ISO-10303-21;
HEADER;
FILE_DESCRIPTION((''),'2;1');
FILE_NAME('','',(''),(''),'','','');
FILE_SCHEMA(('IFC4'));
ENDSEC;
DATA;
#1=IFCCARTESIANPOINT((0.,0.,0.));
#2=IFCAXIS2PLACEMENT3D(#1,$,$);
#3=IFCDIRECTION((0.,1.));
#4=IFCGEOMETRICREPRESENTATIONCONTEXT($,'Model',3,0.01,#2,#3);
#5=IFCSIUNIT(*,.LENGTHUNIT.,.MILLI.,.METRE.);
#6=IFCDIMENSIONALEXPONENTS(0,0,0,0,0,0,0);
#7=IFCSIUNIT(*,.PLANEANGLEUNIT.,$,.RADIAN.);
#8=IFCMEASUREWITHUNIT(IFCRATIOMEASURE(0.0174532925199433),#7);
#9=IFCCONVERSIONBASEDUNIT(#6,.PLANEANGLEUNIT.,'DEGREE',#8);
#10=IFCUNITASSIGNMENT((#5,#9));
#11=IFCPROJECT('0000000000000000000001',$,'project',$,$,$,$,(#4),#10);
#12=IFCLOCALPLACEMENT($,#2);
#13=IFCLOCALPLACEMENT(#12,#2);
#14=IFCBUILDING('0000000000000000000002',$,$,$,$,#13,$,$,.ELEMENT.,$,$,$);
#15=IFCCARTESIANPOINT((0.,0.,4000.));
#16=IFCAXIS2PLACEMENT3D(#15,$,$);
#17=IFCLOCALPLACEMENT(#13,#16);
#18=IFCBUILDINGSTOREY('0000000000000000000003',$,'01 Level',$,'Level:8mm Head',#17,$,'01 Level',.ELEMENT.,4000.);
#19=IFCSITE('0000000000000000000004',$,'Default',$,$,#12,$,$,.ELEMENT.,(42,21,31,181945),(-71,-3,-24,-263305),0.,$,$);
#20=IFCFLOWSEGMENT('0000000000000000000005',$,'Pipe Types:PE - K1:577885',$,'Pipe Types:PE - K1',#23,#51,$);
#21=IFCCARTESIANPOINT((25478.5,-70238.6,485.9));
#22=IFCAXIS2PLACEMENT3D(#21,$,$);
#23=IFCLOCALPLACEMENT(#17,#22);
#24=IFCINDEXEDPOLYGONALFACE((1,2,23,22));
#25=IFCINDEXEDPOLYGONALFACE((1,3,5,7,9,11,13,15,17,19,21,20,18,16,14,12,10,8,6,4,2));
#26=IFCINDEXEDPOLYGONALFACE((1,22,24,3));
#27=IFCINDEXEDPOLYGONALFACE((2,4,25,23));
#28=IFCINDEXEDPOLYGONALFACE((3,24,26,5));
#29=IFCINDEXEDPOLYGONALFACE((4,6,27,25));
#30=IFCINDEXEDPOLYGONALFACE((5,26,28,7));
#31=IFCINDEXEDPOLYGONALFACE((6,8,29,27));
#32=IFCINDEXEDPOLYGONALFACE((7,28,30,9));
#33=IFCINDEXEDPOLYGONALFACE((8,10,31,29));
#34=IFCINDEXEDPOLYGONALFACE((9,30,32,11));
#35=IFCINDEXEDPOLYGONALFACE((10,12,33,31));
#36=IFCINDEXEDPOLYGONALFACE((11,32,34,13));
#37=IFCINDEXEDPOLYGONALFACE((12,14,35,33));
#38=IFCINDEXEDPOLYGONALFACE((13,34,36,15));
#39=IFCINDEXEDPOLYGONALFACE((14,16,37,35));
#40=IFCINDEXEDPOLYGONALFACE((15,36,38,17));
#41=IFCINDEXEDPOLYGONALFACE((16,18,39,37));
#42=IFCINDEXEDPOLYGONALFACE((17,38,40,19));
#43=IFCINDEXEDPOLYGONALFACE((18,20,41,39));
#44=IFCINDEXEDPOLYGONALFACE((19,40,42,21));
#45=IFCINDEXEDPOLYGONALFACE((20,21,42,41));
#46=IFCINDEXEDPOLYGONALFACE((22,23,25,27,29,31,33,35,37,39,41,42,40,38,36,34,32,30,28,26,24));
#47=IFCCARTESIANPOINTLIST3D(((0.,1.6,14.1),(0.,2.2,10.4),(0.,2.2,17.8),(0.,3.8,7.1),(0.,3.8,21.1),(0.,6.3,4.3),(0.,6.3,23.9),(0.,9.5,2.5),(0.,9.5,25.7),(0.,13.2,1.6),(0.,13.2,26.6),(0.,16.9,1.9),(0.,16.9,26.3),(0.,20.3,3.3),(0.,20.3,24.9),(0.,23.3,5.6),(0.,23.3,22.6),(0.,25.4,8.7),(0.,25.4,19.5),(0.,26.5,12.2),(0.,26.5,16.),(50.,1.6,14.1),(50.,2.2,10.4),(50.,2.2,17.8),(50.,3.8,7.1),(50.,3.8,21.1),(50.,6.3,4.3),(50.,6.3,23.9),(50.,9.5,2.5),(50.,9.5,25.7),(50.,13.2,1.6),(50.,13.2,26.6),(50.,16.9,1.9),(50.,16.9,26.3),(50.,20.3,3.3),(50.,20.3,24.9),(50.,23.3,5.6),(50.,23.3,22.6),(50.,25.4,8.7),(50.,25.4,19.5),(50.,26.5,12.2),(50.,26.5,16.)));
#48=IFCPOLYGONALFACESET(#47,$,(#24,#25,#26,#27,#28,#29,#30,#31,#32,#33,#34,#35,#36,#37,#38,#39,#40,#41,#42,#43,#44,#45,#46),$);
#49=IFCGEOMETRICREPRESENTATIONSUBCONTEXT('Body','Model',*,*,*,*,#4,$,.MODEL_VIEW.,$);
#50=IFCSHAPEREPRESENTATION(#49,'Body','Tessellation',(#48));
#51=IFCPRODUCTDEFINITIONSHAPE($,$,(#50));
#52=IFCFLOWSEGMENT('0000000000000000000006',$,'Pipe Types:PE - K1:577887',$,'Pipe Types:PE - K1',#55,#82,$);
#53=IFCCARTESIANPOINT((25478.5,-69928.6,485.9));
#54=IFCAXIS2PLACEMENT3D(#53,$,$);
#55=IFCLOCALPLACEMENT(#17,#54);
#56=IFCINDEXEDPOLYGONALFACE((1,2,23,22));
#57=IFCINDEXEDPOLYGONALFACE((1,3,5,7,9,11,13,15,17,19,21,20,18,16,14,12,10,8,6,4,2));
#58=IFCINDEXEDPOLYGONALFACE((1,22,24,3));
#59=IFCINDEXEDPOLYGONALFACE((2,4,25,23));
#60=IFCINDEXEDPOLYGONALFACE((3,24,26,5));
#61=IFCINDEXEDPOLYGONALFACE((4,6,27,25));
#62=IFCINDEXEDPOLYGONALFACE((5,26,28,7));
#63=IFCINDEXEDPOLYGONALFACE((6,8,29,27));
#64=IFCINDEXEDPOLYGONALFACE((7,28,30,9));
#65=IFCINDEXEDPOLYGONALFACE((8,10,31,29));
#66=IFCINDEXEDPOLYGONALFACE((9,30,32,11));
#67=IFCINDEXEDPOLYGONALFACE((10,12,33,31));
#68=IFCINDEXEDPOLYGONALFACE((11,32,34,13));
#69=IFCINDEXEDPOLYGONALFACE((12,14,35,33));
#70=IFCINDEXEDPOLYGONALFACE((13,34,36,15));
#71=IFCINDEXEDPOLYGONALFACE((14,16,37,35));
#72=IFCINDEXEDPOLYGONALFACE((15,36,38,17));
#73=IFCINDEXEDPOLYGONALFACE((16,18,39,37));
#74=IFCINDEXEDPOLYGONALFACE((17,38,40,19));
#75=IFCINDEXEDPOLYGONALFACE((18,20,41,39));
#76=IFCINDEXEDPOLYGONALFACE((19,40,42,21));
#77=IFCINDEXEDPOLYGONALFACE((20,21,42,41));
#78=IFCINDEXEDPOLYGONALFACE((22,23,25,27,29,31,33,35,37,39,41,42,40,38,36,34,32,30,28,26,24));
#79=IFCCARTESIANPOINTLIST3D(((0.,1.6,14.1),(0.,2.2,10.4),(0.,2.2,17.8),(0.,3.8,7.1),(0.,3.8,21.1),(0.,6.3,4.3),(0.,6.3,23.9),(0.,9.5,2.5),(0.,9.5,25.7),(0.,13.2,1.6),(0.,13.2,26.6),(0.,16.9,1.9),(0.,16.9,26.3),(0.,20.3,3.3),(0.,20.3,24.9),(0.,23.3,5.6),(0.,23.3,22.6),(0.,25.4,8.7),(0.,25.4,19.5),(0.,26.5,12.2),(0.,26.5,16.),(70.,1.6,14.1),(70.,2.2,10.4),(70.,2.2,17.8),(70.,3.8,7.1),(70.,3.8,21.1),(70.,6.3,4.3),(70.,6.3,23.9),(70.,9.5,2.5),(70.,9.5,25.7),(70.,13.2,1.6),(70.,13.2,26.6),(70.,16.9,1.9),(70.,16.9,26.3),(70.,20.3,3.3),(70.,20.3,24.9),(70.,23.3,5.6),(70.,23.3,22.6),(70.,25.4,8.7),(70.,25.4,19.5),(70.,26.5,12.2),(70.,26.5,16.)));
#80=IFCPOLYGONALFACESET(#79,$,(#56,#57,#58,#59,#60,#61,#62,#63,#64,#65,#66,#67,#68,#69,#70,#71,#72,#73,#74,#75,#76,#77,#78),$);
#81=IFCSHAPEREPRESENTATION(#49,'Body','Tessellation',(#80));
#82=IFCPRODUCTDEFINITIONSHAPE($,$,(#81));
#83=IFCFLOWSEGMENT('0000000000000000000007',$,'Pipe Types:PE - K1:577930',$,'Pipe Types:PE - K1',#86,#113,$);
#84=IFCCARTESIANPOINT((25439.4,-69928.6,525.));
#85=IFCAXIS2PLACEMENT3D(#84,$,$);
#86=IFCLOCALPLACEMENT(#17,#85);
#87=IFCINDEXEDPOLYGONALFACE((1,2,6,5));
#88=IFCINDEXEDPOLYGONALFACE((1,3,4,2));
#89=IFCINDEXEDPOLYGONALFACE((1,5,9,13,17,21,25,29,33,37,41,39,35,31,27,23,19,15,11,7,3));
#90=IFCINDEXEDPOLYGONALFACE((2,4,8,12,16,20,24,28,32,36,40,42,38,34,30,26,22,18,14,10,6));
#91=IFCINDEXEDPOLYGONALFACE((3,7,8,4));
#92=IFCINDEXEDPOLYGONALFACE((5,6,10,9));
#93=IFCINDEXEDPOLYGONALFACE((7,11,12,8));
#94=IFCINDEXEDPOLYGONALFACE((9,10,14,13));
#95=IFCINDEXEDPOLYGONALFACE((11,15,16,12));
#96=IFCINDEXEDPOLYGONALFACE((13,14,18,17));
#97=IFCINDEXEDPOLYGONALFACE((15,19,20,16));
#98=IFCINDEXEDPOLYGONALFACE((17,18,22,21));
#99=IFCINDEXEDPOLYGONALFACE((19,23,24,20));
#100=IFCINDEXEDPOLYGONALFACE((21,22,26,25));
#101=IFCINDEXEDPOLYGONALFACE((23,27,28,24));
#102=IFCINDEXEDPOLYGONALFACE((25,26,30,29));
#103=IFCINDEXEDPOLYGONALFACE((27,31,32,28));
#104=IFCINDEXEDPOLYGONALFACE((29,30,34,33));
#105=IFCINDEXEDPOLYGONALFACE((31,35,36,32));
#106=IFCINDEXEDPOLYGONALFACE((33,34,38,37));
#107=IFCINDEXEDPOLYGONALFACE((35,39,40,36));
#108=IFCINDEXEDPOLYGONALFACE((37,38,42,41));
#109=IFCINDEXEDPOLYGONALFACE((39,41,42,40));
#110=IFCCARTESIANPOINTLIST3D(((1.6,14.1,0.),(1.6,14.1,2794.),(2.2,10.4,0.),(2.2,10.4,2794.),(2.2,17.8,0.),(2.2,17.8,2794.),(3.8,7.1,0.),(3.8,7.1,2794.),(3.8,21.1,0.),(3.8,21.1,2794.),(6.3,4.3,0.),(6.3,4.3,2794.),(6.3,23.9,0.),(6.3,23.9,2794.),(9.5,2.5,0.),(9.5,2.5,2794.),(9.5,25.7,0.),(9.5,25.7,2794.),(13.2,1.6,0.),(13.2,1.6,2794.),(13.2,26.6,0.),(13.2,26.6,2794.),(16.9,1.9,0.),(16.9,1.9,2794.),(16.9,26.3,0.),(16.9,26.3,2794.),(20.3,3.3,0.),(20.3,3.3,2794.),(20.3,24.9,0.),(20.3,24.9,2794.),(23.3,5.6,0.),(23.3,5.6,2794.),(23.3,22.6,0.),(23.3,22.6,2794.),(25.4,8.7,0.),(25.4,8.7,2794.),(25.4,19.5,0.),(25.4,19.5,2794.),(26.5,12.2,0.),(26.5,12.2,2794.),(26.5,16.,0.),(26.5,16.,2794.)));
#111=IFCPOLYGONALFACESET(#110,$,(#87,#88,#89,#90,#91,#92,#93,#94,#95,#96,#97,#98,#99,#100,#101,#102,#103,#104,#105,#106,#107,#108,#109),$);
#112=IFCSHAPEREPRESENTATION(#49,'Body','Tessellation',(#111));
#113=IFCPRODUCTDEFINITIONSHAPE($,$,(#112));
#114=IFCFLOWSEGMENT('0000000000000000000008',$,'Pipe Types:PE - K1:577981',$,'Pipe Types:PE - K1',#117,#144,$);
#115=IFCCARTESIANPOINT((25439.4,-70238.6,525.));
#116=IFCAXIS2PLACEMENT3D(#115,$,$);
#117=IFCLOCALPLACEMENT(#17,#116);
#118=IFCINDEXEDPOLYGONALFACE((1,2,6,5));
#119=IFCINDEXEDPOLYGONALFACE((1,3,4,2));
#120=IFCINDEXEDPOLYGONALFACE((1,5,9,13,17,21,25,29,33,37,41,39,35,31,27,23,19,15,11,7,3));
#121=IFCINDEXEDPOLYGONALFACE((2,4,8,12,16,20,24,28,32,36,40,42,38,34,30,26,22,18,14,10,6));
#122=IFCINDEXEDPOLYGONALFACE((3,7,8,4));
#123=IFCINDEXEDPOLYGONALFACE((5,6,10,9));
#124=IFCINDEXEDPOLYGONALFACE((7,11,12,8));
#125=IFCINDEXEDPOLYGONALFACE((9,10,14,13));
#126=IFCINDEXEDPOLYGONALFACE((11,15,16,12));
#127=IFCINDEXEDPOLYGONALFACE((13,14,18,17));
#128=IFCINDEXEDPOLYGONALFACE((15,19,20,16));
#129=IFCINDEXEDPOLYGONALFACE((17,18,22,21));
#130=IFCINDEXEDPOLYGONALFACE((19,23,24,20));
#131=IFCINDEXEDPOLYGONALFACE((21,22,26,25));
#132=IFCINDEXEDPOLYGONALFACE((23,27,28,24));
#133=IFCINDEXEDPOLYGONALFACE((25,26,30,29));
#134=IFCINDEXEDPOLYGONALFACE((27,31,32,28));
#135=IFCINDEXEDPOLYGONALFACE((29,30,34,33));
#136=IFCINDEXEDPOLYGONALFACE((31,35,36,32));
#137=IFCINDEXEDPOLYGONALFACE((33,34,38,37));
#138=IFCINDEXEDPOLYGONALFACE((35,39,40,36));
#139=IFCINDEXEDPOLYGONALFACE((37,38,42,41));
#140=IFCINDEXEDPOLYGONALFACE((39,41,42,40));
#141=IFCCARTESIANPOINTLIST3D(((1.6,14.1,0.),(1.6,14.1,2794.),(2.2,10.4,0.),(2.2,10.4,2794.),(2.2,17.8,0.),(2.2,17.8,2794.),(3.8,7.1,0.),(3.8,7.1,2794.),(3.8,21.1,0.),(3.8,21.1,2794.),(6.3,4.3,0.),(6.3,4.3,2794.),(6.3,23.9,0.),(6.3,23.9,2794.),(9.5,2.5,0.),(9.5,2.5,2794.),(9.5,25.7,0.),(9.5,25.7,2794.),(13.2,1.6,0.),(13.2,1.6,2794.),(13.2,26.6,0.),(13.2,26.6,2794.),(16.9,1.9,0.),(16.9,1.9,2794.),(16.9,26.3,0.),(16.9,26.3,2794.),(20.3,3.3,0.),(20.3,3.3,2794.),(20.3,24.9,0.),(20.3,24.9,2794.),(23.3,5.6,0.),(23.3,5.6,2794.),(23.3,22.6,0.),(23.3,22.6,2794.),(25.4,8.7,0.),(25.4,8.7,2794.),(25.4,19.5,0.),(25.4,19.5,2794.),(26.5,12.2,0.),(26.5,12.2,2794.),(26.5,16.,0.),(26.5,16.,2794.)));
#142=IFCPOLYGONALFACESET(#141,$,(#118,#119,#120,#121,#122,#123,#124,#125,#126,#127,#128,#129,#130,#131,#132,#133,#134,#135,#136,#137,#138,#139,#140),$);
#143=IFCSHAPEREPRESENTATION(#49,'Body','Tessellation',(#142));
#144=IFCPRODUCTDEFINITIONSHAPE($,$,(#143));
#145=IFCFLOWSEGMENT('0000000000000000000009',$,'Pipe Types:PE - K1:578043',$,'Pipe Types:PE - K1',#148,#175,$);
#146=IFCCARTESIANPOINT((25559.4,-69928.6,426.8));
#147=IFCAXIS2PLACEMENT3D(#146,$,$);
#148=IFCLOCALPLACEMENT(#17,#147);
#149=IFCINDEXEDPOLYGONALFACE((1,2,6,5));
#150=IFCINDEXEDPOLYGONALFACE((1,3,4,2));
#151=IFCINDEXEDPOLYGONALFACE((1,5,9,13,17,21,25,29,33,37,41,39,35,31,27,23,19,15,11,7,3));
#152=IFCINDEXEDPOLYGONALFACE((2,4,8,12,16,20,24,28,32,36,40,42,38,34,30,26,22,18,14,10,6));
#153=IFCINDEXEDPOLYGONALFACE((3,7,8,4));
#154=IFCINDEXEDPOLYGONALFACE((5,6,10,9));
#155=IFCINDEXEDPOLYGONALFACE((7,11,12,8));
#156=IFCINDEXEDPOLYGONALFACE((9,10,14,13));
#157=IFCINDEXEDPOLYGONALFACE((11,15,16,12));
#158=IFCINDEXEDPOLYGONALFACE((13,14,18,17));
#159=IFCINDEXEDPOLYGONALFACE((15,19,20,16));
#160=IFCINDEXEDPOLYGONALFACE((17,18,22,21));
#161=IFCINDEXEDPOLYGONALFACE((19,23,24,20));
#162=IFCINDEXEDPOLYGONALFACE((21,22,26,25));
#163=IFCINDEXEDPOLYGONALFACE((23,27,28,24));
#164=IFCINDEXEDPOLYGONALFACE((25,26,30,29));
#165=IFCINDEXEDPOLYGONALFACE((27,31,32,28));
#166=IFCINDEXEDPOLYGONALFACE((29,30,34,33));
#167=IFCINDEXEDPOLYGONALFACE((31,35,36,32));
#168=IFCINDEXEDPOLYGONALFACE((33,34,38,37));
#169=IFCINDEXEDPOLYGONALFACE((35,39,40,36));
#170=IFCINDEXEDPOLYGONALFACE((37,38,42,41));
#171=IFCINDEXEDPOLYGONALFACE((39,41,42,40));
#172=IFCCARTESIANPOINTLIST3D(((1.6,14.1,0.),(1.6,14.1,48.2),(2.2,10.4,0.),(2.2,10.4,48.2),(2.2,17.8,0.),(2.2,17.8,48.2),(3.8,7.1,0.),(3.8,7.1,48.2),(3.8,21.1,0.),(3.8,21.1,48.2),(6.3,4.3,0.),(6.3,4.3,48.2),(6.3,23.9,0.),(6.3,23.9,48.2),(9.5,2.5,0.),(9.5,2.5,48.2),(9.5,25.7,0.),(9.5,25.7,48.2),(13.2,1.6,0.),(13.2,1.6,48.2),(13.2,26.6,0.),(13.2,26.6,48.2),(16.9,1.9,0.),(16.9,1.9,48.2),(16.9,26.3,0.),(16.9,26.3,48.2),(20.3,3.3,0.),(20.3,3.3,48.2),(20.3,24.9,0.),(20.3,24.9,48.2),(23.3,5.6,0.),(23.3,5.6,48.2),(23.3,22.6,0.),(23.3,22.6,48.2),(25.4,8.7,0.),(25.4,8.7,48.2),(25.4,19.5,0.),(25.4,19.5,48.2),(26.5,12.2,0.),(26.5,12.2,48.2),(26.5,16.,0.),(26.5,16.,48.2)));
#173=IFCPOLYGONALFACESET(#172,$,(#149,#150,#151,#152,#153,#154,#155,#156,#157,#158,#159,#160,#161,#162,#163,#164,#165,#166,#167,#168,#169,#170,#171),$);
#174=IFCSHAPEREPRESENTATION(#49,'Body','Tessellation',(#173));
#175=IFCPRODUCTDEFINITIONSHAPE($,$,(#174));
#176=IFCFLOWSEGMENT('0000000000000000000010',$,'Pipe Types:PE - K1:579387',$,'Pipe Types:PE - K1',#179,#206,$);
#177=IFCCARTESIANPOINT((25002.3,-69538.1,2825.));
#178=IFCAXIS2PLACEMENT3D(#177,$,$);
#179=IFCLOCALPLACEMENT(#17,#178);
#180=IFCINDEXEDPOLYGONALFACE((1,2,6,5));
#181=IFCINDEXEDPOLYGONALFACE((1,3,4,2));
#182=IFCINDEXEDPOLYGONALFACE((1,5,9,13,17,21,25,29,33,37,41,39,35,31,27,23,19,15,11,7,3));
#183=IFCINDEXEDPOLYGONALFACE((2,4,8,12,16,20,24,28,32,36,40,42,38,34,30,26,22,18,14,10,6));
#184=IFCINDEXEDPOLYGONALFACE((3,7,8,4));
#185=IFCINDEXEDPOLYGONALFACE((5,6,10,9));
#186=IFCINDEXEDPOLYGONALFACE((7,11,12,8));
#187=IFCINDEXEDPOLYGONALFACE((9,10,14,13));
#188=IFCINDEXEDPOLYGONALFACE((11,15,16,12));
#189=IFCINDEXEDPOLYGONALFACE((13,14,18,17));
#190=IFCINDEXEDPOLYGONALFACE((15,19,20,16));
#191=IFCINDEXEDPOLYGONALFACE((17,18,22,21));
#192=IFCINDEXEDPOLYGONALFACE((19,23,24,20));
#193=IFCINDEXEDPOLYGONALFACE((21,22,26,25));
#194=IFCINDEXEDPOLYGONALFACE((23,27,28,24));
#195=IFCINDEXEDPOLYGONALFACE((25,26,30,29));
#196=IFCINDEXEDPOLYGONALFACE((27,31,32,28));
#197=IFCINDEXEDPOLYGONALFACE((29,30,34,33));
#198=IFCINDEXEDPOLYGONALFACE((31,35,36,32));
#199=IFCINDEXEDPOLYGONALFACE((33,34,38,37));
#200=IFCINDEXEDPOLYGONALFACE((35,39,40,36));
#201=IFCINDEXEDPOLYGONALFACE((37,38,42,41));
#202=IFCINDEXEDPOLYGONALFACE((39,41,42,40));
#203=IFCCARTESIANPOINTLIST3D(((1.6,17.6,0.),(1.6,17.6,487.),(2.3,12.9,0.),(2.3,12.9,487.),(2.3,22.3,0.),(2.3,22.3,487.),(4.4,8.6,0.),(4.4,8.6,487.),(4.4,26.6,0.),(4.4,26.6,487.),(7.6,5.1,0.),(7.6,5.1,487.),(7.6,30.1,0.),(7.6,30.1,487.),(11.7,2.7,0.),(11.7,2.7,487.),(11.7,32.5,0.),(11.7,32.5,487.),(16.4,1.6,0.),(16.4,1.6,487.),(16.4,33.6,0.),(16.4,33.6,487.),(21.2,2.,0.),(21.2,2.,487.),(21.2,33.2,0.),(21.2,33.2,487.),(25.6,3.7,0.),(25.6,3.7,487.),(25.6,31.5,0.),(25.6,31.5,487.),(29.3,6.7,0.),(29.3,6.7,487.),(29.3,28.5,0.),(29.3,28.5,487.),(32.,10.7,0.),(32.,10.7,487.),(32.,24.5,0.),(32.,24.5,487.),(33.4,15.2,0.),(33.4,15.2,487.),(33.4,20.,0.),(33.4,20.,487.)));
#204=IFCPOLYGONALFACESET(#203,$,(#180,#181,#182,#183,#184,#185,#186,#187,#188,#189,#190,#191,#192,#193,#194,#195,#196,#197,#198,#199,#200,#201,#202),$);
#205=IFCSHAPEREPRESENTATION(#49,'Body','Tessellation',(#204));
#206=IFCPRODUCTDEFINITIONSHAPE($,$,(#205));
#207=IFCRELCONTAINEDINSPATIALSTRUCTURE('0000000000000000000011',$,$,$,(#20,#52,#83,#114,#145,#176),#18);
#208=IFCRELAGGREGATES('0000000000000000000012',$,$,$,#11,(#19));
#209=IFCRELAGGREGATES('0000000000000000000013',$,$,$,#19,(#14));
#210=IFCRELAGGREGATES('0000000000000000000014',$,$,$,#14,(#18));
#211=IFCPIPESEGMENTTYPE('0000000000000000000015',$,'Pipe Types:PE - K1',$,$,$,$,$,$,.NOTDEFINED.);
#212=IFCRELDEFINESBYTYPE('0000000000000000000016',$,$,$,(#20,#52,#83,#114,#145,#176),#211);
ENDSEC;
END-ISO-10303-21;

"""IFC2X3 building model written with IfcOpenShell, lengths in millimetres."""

from ifc_helpers import new_model, entity, si_unit, converted_unit, direction, frame, frame_2d, origin, origin_2d_with_axis, place, context, subcontext, project, spatial, circle, extrude, type_object, element, save


model = new_model("IFC2X3")

# Units and contexts
model_context = context("Model", 3, precision=0.01, world=origin(), true_north=direction((0.0, 1.0)))
body_context = subcontext(model_context, "Body", "Model", "MODEL_VIEW")
ifc_project = project(units=[si_unit("LENGTHUNIT", "METRE", prefix="MILLI"), converted_unit("PLANEANGLEUNIT", "DEGREE", entity("IfcRatioMeasure", 0.0174532925199433), si_unit("PLANEANGLEUNIT", "RADIAN"), dimensions=[0, 0, 0, 0, 0, 0, 0])], contexts=[model_context])

# Site, building, storey
site_placement = place(None, origin())
site = spatial("IfcSite", under=ifc_project, at=site_placement, Name="Default", CompositionType="ELEMENT", RefLatitude=(42, 21, 31, 181945), RefLongitude=(-71, -3, -24, -263305), RefElevation=0.0)
building_placement = place(site_placement, origin())
building = spatial("IfcBuilding", under=site, at=building_placement, CompositionType="ELEMENT")
storey_placement = place(building_placement, frame((0.0, 0.0, 4000.0)))
storey = spatial("IfcBuildingStorey", under=building, at=storey_placement, Name="01 Level", ObjectType="Level:8mm Head", LongName="01 Level", CompositionType="ELEMENT", Elevation=4000.0)

# Flow segments
pipe_segment_type = type_object("IfcPipeSegmentType", Name="Pipe Types:PE - K1", PredefinedType="NOTDEFINED")
flow_segment_1_placement = place(storey_placement, frame((25478.5, -70238.6, 485.9)))
element("IfcFlowSegment", 1, at=flow_segment_1_placement, inside=storey, type_object=pipe_segment_type, Name="Pipe Types:PE - K1:577885", ObjectType="Pipe Types:PE - K1", context=body_context, shape_type="SweptSolid", body=[
    extrude(circle(Radius=12.5, at=origin_2d_with_axis()), frame((0.0, 14.1, 14.1), z_axis=(1.0, 0.0, 0.0), x_axis=(0.0, -1.0, 0.0)), (0.0, 0.0, 1.0), 50.0),
])
flow_segment_2_placement = place(storey_placement, frame((25478.5, -69928.6, 485.9)))
element("IfcFlowSegment", 2, at=flow_segment_2_placement, inside=storey, type_object=pipe_segment_type, Name="Pipe Types:PE - K1:577887", ObjectType="Pipe Types:PE - K1", context=body_context, shape_type="SweptSolid", body=[
    extrude(circle(Radius=12.5, at=frame_2d((0.0, 0.0), x_axis=(1.0, 0.0))), frame((0.0, 14.1, 14.1), z_axis=(1.0, 0.0, 0.0), x_axis=(0.0, -1.0, 0.0)), (0.0, 0.0, 1.0), 70.0),
])
flow_segment_3_placement = place(storey_placement, frame((25439.4, -69928.6, 525.0)))
element("IfcFlowSegment", 3, at=flow_segment_3_placement, inside=storey, type_object=pipe_segment_type, Name="Pipe Types:PE - K1:577930", ObjectType="Pipe Types:PE - K1", context=body_context, shape_type="SweptSolid", body=[
    extrude(circle(Radius=12.5, at=frame_2d((0.0, 0.0), x_axis=(1.0, 0.0))), frame((14.1, 14.1, 0.0), z_axis=(0.0, 0.0, 1.0), x_axis=(-1.0, 0.0, 0.0)), (0.0, 0.0, 1.0), 2794.0),
])
flow_segment_4_placement = place(storey_placement, frame((25439.4, -70238.6, 525.0)))
element("IfcFlowSegment", 4, at=flow_segment_4_placement, inside=storey, type_object=pipe_segment_type, Name="Pipe Types:PE - K1:577981", ObjectType="Pipe Types:PE - K1", context=body_context, shape_type="SweptSolid", body=[
    extrude(circle(Radius=12.5, at=origin_2d_with_axis()), frame((14.1, 14.1, 0.0), z_axis=(0.0, 0.0, 1.0), x_axis=(-1.0, 0.0, 0.0)), (0.0, 0.0, 1.0), 2794.0),
])
flow_segment_5_placement = place(storey_placement, frame((25559.4, -69928.6, 426.8)))
element("IfcFlowSegment", 5, at=flow_segment_5_placement, inside=storey, type_object=pipe_segment_type, Name="Pipe Types:PE - K1:578043", ObjectType="Pipe Types:PE - K1", context=body_context, shape_type="SweptSolid", body=[
    extrude(circle(Radius=12.5, at=frame_2d((0.0, 0.0), x_axis=(1.0, 0.0))), frame((14.1, 14.1, 0.0), z_axis=(0.0, 0.0, 1.0), x_axis=(-1.0, 0.0, 0.0)), (0.0, 0.0, 1.0), 48.2),
])
flow_segment_6_placement = place(storey_placement, frame((25002.3, -69538.1, 2825.0)))
element("IfcFlowSegment", 6, at=flow_segment_6_placement, inside=storey, type_object=pipe_segment_type, Name="Pipe Types:PE - K1:579387", ObjectType="Pipe Types:PE - K1", context=body_context, shape_type="SweptSolid", body=[
    extrude(circle(Radius=16.0, at=origin_2d_with_axis()), frame((17.6, 17.6, 0.0), z_axis=(0.0, 0.0, 1.0), x_axis=(-1.0, 0.0, 0.0)), (0.0, 0.0, 1.0), 487.0),
])

save(model, "model.ifc")
